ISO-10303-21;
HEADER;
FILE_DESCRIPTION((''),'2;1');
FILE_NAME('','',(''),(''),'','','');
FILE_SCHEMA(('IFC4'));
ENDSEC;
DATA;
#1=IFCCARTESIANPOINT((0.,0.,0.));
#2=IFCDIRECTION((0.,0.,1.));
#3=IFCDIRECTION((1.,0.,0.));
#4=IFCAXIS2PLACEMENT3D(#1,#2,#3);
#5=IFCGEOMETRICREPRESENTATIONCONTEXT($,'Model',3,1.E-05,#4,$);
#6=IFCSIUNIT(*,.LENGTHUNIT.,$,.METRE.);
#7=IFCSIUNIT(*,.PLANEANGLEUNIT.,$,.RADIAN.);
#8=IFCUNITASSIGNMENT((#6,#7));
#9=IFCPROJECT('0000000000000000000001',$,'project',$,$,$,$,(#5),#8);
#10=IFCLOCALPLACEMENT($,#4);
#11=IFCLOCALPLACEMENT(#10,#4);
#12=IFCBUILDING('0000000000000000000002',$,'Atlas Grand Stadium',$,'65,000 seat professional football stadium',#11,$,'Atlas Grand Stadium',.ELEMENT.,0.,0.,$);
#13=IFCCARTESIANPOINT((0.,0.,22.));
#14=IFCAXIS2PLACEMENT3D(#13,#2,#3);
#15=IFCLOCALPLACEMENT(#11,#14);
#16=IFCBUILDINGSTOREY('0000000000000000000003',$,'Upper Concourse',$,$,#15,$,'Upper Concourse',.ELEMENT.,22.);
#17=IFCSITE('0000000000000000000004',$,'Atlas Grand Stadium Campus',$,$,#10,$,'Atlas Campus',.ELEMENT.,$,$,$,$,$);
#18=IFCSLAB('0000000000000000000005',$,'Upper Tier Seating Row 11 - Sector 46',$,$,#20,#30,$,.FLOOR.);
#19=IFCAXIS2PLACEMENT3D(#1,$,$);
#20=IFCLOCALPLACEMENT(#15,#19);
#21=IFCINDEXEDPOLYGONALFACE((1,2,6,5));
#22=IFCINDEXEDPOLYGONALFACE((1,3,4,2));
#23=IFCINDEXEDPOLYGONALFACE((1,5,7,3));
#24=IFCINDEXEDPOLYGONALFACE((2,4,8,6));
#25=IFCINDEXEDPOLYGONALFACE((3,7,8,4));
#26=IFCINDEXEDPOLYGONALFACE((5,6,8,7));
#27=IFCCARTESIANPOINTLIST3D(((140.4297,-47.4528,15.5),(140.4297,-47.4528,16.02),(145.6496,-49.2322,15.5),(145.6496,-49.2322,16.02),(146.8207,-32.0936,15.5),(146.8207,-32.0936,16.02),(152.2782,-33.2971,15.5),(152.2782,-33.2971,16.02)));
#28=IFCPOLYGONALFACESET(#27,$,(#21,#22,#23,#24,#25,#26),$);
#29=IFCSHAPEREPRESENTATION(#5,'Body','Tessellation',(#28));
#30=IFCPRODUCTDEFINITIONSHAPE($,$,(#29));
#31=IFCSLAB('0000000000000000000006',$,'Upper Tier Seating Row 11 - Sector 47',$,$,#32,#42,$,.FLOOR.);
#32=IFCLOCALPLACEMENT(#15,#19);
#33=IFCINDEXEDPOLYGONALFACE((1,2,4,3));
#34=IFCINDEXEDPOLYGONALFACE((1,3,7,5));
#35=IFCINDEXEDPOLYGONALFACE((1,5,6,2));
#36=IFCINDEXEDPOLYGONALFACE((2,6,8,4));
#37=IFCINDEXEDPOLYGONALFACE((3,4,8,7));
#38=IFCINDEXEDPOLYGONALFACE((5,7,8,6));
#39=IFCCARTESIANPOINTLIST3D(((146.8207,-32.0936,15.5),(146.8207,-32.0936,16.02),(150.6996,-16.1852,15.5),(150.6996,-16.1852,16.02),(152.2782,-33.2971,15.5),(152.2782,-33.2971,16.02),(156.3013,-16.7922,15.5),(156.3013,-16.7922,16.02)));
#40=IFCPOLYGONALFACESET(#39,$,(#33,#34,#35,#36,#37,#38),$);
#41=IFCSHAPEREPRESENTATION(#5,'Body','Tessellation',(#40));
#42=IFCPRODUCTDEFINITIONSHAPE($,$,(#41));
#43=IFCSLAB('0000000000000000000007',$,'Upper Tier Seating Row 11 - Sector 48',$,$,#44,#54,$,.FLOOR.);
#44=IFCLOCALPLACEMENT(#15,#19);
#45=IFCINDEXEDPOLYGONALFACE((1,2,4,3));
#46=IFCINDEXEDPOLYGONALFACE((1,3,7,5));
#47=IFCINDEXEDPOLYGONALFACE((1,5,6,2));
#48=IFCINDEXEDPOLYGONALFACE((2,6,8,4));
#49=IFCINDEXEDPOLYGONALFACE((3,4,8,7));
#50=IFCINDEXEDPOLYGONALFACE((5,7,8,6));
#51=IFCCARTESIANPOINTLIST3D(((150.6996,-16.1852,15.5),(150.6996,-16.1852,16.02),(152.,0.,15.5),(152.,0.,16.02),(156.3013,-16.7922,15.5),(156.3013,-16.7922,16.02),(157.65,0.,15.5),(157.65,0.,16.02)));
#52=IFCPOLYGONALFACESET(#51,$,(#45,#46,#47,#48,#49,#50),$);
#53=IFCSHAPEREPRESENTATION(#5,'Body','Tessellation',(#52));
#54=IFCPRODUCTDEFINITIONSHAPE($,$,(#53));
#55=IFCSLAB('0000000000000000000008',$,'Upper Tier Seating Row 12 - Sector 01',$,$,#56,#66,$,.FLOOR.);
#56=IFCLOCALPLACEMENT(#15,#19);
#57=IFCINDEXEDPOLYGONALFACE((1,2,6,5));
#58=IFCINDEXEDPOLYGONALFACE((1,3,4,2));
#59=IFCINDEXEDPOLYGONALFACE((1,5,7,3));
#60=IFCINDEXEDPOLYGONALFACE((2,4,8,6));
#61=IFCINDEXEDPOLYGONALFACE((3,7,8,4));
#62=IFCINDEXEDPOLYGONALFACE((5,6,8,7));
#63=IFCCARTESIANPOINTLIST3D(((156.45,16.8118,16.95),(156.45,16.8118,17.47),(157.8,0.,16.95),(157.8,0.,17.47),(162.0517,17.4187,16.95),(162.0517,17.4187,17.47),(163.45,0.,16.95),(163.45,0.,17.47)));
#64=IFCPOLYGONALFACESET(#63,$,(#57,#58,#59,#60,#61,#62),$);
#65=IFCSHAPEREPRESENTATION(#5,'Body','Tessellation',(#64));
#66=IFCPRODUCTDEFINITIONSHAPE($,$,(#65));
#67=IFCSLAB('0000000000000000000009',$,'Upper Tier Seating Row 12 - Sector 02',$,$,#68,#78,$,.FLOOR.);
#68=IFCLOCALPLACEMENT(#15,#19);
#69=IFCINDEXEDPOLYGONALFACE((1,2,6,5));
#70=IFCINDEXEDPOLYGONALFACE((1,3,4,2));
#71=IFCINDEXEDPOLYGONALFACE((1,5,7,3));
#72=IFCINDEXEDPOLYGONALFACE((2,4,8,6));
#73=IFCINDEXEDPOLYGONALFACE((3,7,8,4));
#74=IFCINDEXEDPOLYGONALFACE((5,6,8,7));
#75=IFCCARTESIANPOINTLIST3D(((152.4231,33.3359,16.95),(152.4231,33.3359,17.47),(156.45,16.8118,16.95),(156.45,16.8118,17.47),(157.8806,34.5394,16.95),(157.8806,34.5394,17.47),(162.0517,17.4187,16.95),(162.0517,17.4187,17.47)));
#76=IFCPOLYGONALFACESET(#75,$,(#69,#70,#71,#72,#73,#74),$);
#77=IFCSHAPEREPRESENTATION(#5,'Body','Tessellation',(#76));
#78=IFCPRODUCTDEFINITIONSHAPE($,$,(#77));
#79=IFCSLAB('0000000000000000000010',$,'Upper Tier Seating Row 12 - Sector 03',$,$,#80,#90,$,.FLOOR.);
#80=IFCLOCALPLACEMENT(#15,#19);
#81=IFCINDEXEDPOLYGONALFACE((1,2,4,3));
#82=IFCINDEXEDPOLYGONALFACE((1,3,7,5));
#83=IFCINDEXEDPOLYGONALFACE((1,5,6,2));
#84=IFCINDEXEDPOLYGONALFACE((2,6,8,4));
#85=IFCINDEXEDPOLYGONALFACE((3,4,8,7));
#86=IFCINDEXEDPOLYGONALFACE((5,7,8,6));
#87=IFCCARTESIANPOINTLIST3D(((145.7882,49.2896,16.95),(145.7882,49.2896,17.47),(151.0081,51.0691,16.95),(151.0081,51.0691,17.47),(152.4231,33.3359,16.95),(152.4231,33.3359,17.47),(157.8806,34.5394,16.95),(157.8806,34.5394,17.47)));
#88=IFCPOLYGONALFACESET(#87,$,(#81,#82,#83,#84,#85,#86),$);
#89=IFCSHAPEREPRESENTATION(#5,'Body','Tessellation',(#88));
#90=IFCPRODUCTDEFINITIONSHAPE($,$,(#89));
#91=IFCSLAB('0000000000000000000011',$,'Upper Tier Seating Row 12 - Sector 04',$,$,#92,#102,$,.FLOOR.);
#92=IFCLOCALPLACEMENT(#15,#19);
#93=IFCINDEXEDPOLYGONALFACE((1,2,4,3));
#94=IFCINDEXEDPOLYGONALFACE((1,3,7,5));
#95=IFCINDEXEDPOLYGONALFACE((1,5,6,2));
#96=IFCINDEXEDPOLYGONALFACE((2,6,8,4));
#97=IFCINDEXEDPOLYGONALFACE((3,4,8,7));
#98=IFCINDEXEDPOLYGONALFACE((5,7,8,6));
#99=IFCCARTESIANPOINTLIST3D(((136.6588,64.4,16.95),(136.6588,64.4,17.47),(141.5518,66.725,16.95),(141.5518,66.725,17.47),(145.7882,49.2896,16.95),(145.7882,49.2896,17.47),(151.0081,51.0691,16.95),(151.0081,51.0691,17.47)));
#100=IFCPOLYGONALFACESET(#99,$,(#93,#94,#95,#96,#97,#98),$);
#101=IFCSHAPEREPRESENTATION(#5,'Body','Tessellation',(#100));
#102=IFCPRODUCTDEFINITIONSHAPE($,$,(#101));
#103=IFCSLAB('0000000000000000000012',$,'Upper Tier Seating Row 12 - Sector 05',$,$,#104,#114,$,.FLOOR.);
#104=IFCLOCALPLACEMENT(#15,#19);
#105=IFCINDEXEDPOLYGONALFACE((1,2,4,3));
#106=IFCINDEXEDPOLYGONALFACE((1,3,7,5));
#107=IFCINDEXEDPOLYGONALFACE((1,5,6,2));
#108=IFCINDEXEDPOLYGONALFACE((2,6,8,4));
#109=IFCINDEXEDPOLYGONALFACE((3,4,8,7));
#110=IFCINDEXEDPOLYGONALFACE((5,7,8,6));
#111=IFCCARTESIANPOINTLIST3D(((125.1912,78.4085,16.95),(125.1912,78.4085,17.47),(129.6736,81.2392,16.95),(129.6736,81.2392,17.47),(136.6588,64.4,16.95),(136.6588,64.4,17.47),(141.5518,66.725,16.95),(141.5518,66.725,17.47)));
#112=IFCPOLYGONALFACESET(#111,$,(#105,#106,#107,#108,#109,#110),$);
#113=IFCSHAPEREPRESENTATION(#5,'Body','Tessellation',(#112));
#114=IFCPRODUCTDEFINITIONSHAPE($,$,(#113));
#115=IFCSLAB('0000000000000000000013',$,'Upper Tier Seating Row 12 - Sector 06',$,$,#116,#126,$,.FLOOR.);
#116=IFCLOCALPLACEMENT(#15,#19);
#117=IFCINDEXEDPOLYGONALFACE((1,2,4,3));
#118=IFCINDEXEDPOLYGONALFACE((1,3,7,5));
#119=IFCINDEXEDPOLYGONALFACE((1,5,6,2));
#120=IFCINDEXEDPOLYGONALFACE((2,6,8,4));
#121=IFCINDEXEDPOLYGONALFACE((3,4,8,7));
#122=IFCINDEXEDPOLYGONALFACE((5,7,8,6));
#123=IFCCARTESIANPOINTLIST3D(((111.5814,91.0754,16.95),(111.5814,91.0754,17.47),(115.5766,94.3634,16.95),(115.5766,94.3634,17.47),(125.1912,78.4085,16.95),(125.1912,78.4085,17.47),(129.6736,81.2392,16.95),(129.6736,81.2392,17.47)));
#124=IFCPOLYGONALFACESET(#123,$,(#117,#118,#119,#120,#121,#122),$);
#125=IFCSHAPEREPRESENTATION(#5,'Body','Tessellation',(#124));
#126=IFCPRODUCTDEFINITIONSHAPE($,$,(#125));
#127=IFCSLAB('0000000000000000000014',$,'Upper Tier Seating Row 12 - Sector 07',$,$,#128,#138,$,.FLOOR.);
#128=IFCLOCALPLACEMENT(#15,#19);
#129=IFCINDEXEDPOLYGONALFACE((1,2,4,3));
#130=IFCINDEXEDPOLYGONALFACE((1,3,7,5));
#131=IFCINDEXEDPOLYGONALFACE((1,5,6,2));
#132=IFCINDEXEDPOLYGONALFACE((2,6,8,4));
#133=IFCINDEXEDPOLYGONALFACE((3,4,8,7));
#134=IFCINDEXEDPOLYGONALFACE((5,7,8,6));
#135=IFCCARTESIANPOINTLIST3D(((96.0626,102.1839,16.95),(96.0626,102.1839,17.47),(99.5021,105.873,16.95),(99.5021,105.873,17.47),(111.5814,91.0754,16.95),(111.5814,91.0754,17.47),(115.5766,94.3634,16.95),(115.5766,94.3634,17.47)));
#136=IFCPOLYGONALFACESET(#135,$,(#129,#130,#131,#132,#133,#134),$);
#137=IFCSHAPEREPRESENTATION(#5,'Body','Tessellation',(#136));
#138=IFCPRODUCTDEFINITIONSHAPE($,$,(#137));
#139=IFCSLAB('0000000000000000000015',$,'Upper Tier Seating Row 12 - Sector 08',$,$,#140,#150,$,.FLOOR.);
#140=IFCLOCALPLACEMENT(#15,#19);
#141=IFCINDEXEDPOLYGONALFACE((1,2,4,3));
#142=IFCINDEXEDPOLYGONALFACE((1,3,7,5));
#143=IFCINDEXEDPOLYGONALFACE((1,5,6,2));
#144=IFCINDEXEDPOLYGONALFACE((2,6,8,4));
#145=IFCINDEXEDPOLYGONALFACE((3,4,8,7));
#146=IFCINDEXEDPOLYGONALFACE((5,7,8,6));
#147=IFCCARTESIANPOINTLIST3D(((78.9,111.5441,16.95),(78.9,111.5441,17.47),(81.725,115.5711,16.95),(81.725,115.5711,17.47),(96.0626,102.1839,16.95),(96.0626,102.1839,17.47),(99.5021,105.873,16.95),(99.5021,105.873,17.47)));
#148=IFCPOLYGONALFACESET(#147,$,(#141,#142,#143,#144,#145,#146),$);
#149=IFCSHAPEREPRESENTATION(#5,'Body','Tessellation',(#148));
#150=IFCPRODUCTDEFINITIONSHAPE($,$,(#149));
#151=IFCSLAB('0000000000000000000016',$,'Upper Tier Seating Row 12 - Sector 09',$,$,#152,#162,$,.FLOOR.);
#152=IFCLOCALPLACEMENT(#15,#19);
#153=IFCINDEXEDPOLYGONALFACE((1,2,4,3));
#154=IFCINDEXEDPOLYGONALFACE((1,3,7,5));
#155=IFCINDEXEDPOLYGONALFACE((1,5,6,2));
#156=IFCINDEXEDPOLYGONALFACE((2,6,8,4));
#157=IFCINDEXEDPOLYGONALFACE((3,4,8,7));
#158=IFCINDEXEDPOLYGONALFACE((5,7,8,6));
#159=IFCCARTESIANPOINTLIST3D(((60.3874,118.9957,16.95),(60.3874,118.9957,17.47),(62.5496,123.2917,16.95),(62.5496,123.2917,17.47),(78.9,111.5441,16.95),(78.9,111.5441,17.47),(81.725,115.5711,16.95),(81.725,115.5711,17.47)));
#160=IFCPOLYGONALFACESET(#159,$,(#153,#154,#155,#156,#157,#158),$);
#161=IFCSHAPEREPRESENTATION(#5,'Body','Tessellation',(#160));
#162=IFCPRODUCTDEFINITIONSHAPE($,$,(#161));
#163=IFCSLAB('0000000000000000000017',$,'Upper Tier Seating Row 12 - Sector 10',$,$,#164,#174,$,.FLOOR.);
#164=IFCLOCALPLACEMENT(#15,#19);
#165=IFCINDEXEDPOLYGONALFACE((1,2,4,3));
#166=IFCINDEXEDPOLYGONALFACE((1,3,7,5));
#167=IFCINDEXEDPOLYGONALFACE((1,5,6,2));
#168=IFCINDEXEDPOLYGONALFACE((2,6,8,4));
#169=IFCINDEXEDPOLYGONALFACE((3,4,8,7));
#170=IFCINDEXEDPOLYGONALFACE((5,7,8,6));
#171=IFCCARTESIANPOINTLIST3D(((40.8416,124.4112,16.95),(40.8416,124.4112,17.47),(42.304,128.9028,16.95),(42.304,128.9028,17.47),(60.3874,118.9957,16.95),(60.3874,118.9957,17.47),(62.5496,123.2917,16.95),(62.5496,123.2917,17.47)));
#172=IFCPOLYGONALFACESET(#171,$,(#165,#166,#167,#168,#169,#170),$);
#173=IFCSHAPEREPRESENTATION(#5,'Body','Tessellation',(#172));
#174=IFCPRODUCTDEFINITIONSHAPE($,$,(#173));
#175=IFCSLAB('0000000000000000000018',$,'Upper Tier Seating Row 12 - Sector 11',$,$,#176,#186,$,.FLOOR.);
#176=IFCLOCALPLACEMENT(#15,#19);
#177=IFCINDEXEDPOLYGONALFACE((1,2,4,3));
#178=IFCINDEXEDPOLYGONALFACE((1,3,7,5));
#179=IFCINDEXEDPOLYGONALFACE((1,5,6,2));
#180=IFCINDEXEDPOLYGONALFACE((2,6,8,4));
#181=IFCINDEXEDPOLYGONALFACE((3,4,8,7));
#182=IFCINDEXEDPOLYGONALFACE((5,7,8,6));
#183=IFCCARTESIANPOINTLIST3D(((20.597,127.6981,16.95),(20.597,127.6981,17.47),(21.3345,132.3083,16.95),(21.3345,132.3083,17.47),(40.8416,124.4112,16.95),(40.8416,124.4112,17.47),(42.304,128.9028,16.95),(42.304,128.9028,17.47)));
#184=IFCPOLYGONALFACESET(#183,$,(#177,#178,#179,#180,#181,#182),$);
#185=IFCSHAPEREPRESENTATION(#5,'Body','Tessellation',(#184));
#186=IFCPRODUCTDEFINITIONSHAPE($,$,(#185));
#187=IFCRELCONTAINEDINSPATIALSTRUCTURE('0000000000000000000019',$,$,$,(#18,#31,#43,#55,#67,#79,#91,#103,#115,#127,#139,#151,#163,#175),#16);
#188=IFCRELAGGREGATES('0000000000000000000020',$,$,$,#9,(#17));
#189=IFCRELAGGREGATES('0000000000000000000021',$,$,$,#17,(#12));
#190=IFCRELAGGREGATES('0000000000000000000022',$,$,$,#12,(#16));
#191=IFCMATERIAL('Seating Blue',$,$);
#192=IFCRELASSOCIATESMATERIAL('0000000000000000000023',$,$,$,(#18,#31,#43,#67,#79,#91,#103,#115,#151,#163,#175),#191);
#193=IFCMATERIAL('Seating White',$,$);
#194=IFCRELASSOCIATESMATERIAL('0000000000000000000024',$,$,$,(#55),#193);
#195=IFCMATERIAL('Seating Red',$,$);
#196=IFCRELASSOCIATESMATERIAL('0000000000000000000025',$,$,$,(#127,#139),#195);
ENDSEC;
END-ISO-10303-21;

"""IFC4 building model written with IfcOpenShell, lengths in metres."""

from ifc_helpers import new_model, si_unit, frame, origin_with_axes, place, context, project, spatial, polyline, outline, extrude, material, element, save


model = new_model("IFC4")

# Units and contexts
model_context = context("Model", 3, precision=1e-05, world=origin_with_axes())
ifc_project = project(units=[si_unit("LENGTHUNIT", "METRE"), si_unit("PLANEANGLEUNIT", "RADIAN")], contexts=[model_context])

# Site, building, storey
site_placement = place(None, origin_with_axes())
site = spatial("IfcSite", under=ifc_project, at=site_placement, Name="Atlas Grand Stadium Campus", LongName="Atlas Campus", CompositionType="ELEMENT")
building_placement = place(site_placement, origin_with_axes())
building = spatial("IfcBuilding", under=site, at=building_placement, Name="Atlas Grand Stadium", ObjectType="65,000 seat professional football stadium", LongName="Atlas Grand Stadium", CompositionType="ELEMENT", ElevationOfRefHeight=0.0, ElevationOfTerrain=0.0)
storey_placement = place(building_placement, frame((0.0, 0.0, 22.0), z_axis=(0.0, 0.0, 1.0), x_axis=(1.0, 0.0, 0.0)))
storey = spatial("IfcBuildingStorey", under=building, at=storey_placement, Name="Upper Concourse", LongName="Upper Concourse", CompositionType="ELEMENT", Elevation=22.0)

# Slabs
ifc_material_1 = material(Name="Seating Blue")
slab_1_placement = place(storey_placement, frame((0.0, 0.0, 15.5), z_axis=(0.0, 0.0, 1.0), x_axis=(1.0, 0.0, 0.0)))
element("IfcSlab", 1, at=slab_1_placement, inside=storey, material=ifc_material_1, Name="Upper Tier Seating Row 11 - Sector 46", PredefinedType="FLOOR", context=model_context, shape_type="SweptSolid", body=[
    extrude(outline(polyline([(145.6496, -49.2322), (152.2782, -33.2971), (146.8207, -32.0936), (140.4297, -47.4528), (145.6496, -49.2322)])), origin_with_axes(), (0.0, 0.0, 1.0), 0.52),
])
slab_2_placement = place(storey_placement, frame((0.0, 0.0, 15.5), z_axis=(0.0, 0.0, 1.0), x_axis=(1.0, 0.0, 0.0)))
element("IfcSlab", 2, at=slab_2_placement, inside=storey, material=ifc_material_1, Name="Upper Tier Seating Row 11 - Sector 47", PredefinedType="FLOOR", context=model_context, shape_type="SweptSolid", body=[
    extrude(outline(polyline([(152.2782, -33.2971), (156.3013, -16.7922), (150.6996, -16.1852), (146.8207, -32.0936), (152.2782, -33.2971)])), origin_with_axes(), (0.0, 0.0, 1.0), 0.52),
])
slab_3_placement = place(storey_placement, frame((0.0, 0.0, 15.5), z_axis=(0.0, 0.0, 1.0), x_axis=(1.0, 0.0, 0.0)))
element("IfcSlab", 3, at=slab_3_placement, inside=storey, material=ifc_material_1, Name="Upper Tier Seating Row 11 - Sector 48", PredefinedType="FLOOR", context=model_context, shape_type="SweptSolid", body=[
    extrude(outline(polyline([(156.3013, -16.7922), (157.65, 0.0), (152.0, 0.0), (150.6996, -16.1852), (156.3013, -16.7922)])), origin_with_axes(), (0.0, 0.0, 1.0), 0.52),
])
ifc_material_2 = material(Name="Seating White")
slab_4_placement = place(storey_placement, frame((0.0, 0.0, 16.95), z_axis=(0.0, 0.0, 1.0), x_axis=(1.0, 0.0, 0.0)))
element("IfcSlab", 4, at=slab_4_placement, inside=storey, material=ifc_material_2, Name="Upper Tier Seating Row 12 - Sector 01", PredefinedType="FLOOR", context=model_context, shape_type="SweptSolid", body=[
    extrude(outline(polyline([(163.45, 0.0), (162.0517, 17.4187), (156.45, 16.8118), (157.8, 0.0), (163.45, 0.0)])), origin_with_axes(), (0.0, 0.0, 1.0), 0.52),
])
slab_5_placement = place(storey_placement, frame((0.0, 0.0, 16.95), z_axis=(0.0, 0.0, 1.0), x_axis=(1.0, 0.0, 0.0)))
element("IfcSlab", 5, at=slab_5_placement, inside=storey, material=ifc_material_1, Name="Upper Tier Seating Row 12 - Sector 02", PredefinedType="FLOOR", context=model_context, shape_type="SweptSolid", body=[
    extrude(outline(polyline([(162.0517, 17.4187), (157.8806, 34.5394), (152.4231, 33.3359), (156.45, 16.8118), (162.0517, 17.4187)])), origin_with_axes(), (0.0, 0.0, 1.0), 0.52),
])
slab_6_placement = place(storey_placement, frame((0.0, 0.0, 16.95), z_axis=(0.0, 0.0, 1.0), x_axis=(1.0, 0.0, 0.0)))
element("IfcSlab", 6, at=slab_6_placement, inside=storey, material=ifc_material_1, Name="Upper Tier Seating Row 12 - Sector 03", PredefinedType="FLOOR", context=model_context, shape_type="SweptSolid", body=[
    extrude(outline(polyline([(157.8806, 34.5394), (151.0081, 51.0691), (145.7882, 49.2896), (152.4231, 33.3359), (157.8806, 34.5394)])), origin_with_axes(), (0.0, 0.0, 1.0), 0.52),
])
slab_7_placement = place(storey_placement, frame((0.0, 0.0, 16.95), z_axis=(0.0, 0.0, 1.0), x_axis=(1.0, 0.0, 0.0)))
element("IfcSlab", 7, at=slab_7_placement, inside=storey, material=ifc_material_1, Name="Upper Tier Seating Row 12 - Sector 04", PredefinedType="FLOOR", context=model_context, shape_type="SweptSolid", body=[
    extrude(outline(polyline([(151.0081, 51.0691), (141.5519, 66.725), (136.6588, 64.4), (145.7882, 49.2896), (151.0081, 51.0691)])), origin_with_axes(), (0.0, 0.0, 1.0), 0.52),
])
slab_8_placement = place(storey_placement, frame((0.0, 0.0, 16.95), z_axis=(0.0, 0.0, 1.0), x_axis=(1.0, 0.0, 0.0)))
element("IfcSlab", 8, at=slab_8_placement, inside=storey, material=ifc_material_1, Name="Upper Tier Seating Row 12 - Sector 05", PredefinedType="FLOOR", context=model_context, shape_type="SweptSolid", body=[
    extrude(outline(polyline([(141.5519, 66.725), (129.6736, 81.2392), (125.1912, 78.4085), (136.6588, 64.4), (141.5519, 66.725)])), origin_with_axes(), (0.0, 0.0, 1.0), 0.52),
])
slab_9_placement = place(storey_placement, frame((0.0, 0.0, 16.95), z_axis=(0.0, 0.0, 1.0), x_axis=(1.0, 0.0, 0.0)))
element("IfcSlab", 9, at=slab_9_placement, inside=storey, material=ifc_material_1, Name="Upper Tier Seating Row 12 - Sector 06", PredefinedType="FLOOR", context=model_context, shape_type="SweptSolid", body=[
    extrude(outline(polyline([(129.6736, 81.2392), (115.5766, 94.3634), (111.5815, 91.0754), (125.1912, 78.4085), (129.6736, 81.2392)])), origin_with_axes(), (0.0, 0.0, 1.0), 0.52),
])
ifc_material_3 = material(Name="Seating Red")
slab_10_placement = place(storey_placement, frame((0.0, 0.0, 16.95), z_axis=(0.0, 0.0, 1.0), x_axis=(1.0, 0.0, 0.0)))
element("IfcSlab", 10, at=slab_10_placement, inside=storey, material=ifc_material_3, Name="Upper Tier Seating Row 12 - Sector 07", PredefinedType="FLOOR", context=model_context, shape_type="SweptSolid", body=[
    extrude(outline(polyline([(115.5766, 94.3634), (99.5021, 105.873), (96.0626, 102.1839), (111.5815, 91.0754), (115.5766, 94.3634)])), origin_with_axes(), (0.0, 0.0, 1.0), 0.52),
])
slab_11_placement = place(storey_placement, frame((0.0, 0.0, 16.95), z_axis=(0.0, 0.0, 1.0), x_axis=(1.0, 0.0, 0.0)))
element("IfcSlab", 11, at=slab_11_placement, inside=storey, material=ifc_material_3, Name="Upper Tier Seating Row 12 - Sector 08", PredefinedType="FLOOR", context=model_context, shape_type="SweptSolid", body=[
    extrude(outline(polyline([(99.5021, 105.873), (81.725, 115.5711), (78.9, 111.5441), (96.0626, 102.1839), (99.5021, 105.873)])), origin_with_axes(), (0.0, 0.0, 1.0), 0.52),
])
slab_12_placement = place(storey_placement, frame((0.0, 0.0, 16.95), z_axis=(0.0, 0.0, 1.0), x_axis=(1.0, 0.0, 0.0)))
element("IfcSlab", 12, at=slab_12_placement, inside=storey, material=ifc_material_1, Name="Upper Tier Seating Row 12 - Sector 09", PredefinedType="FLOOR", context=model_context, shape_type="SweptSolid", body=[
    extrude(outline(polyline([(81.725, 115.5711), (62.5496, 123.2917), (60.3875, 118.9957), (78.9, 111.5441), (81.725, 115.5711)])), origin_with_axes(), (0.0, 0.0, 1.0), 0.52),
])
slab_13_placement = place(storey_placement, frame((0.0, 0.0, 16.95), z_axis=(0.0, 0.0, 1.0), x_axis=(1.0, 0.0, 0.0)))
element("IfcSlab", 13, at=slab_13_placement, inside=storey, material=ifc_material_1, Name="Upper Tier Seating Row 12 - Sector 10", PredefinedType="FLOOR", context=model_context, shape_type="SweptSolid", body=[
    extrude(outline(polyline([(62.5496, 123.2917), (42.304, 128.9028), (40.8417, 124.4112), (60.3875, 118.9957), (62.5496, 123.2917)])), origin_with_axes(), (0.0, 0.0, 1.0), 0.52),
])
slab_14_placement = place(storey_placement, frame((0.0, 0.0, 16.95), z_axis=(0.0, 0.0, 1.0), x_axis=(1.0, 0.0, 0.0)))
element("IfcSlab", 14, at=slab_14_placement, inside=storey, material=ifc_material_1, Name="Upper Tier Seating Row 12 - Sector 11", PredefinedType="FLOOR", context=model_context, shape_type="SweptSolid", body=[
    extrude(outline(polyline([(42.304, 128.9028), (21.3345, 132.3083), (20.597, 127.6981), (40.8417, 124.4112), (42.304, 128.9028)])), origin_with_axes(), (0.0, 0.0, 1.0), 0.52),
])

save(model, "model.ifc")
